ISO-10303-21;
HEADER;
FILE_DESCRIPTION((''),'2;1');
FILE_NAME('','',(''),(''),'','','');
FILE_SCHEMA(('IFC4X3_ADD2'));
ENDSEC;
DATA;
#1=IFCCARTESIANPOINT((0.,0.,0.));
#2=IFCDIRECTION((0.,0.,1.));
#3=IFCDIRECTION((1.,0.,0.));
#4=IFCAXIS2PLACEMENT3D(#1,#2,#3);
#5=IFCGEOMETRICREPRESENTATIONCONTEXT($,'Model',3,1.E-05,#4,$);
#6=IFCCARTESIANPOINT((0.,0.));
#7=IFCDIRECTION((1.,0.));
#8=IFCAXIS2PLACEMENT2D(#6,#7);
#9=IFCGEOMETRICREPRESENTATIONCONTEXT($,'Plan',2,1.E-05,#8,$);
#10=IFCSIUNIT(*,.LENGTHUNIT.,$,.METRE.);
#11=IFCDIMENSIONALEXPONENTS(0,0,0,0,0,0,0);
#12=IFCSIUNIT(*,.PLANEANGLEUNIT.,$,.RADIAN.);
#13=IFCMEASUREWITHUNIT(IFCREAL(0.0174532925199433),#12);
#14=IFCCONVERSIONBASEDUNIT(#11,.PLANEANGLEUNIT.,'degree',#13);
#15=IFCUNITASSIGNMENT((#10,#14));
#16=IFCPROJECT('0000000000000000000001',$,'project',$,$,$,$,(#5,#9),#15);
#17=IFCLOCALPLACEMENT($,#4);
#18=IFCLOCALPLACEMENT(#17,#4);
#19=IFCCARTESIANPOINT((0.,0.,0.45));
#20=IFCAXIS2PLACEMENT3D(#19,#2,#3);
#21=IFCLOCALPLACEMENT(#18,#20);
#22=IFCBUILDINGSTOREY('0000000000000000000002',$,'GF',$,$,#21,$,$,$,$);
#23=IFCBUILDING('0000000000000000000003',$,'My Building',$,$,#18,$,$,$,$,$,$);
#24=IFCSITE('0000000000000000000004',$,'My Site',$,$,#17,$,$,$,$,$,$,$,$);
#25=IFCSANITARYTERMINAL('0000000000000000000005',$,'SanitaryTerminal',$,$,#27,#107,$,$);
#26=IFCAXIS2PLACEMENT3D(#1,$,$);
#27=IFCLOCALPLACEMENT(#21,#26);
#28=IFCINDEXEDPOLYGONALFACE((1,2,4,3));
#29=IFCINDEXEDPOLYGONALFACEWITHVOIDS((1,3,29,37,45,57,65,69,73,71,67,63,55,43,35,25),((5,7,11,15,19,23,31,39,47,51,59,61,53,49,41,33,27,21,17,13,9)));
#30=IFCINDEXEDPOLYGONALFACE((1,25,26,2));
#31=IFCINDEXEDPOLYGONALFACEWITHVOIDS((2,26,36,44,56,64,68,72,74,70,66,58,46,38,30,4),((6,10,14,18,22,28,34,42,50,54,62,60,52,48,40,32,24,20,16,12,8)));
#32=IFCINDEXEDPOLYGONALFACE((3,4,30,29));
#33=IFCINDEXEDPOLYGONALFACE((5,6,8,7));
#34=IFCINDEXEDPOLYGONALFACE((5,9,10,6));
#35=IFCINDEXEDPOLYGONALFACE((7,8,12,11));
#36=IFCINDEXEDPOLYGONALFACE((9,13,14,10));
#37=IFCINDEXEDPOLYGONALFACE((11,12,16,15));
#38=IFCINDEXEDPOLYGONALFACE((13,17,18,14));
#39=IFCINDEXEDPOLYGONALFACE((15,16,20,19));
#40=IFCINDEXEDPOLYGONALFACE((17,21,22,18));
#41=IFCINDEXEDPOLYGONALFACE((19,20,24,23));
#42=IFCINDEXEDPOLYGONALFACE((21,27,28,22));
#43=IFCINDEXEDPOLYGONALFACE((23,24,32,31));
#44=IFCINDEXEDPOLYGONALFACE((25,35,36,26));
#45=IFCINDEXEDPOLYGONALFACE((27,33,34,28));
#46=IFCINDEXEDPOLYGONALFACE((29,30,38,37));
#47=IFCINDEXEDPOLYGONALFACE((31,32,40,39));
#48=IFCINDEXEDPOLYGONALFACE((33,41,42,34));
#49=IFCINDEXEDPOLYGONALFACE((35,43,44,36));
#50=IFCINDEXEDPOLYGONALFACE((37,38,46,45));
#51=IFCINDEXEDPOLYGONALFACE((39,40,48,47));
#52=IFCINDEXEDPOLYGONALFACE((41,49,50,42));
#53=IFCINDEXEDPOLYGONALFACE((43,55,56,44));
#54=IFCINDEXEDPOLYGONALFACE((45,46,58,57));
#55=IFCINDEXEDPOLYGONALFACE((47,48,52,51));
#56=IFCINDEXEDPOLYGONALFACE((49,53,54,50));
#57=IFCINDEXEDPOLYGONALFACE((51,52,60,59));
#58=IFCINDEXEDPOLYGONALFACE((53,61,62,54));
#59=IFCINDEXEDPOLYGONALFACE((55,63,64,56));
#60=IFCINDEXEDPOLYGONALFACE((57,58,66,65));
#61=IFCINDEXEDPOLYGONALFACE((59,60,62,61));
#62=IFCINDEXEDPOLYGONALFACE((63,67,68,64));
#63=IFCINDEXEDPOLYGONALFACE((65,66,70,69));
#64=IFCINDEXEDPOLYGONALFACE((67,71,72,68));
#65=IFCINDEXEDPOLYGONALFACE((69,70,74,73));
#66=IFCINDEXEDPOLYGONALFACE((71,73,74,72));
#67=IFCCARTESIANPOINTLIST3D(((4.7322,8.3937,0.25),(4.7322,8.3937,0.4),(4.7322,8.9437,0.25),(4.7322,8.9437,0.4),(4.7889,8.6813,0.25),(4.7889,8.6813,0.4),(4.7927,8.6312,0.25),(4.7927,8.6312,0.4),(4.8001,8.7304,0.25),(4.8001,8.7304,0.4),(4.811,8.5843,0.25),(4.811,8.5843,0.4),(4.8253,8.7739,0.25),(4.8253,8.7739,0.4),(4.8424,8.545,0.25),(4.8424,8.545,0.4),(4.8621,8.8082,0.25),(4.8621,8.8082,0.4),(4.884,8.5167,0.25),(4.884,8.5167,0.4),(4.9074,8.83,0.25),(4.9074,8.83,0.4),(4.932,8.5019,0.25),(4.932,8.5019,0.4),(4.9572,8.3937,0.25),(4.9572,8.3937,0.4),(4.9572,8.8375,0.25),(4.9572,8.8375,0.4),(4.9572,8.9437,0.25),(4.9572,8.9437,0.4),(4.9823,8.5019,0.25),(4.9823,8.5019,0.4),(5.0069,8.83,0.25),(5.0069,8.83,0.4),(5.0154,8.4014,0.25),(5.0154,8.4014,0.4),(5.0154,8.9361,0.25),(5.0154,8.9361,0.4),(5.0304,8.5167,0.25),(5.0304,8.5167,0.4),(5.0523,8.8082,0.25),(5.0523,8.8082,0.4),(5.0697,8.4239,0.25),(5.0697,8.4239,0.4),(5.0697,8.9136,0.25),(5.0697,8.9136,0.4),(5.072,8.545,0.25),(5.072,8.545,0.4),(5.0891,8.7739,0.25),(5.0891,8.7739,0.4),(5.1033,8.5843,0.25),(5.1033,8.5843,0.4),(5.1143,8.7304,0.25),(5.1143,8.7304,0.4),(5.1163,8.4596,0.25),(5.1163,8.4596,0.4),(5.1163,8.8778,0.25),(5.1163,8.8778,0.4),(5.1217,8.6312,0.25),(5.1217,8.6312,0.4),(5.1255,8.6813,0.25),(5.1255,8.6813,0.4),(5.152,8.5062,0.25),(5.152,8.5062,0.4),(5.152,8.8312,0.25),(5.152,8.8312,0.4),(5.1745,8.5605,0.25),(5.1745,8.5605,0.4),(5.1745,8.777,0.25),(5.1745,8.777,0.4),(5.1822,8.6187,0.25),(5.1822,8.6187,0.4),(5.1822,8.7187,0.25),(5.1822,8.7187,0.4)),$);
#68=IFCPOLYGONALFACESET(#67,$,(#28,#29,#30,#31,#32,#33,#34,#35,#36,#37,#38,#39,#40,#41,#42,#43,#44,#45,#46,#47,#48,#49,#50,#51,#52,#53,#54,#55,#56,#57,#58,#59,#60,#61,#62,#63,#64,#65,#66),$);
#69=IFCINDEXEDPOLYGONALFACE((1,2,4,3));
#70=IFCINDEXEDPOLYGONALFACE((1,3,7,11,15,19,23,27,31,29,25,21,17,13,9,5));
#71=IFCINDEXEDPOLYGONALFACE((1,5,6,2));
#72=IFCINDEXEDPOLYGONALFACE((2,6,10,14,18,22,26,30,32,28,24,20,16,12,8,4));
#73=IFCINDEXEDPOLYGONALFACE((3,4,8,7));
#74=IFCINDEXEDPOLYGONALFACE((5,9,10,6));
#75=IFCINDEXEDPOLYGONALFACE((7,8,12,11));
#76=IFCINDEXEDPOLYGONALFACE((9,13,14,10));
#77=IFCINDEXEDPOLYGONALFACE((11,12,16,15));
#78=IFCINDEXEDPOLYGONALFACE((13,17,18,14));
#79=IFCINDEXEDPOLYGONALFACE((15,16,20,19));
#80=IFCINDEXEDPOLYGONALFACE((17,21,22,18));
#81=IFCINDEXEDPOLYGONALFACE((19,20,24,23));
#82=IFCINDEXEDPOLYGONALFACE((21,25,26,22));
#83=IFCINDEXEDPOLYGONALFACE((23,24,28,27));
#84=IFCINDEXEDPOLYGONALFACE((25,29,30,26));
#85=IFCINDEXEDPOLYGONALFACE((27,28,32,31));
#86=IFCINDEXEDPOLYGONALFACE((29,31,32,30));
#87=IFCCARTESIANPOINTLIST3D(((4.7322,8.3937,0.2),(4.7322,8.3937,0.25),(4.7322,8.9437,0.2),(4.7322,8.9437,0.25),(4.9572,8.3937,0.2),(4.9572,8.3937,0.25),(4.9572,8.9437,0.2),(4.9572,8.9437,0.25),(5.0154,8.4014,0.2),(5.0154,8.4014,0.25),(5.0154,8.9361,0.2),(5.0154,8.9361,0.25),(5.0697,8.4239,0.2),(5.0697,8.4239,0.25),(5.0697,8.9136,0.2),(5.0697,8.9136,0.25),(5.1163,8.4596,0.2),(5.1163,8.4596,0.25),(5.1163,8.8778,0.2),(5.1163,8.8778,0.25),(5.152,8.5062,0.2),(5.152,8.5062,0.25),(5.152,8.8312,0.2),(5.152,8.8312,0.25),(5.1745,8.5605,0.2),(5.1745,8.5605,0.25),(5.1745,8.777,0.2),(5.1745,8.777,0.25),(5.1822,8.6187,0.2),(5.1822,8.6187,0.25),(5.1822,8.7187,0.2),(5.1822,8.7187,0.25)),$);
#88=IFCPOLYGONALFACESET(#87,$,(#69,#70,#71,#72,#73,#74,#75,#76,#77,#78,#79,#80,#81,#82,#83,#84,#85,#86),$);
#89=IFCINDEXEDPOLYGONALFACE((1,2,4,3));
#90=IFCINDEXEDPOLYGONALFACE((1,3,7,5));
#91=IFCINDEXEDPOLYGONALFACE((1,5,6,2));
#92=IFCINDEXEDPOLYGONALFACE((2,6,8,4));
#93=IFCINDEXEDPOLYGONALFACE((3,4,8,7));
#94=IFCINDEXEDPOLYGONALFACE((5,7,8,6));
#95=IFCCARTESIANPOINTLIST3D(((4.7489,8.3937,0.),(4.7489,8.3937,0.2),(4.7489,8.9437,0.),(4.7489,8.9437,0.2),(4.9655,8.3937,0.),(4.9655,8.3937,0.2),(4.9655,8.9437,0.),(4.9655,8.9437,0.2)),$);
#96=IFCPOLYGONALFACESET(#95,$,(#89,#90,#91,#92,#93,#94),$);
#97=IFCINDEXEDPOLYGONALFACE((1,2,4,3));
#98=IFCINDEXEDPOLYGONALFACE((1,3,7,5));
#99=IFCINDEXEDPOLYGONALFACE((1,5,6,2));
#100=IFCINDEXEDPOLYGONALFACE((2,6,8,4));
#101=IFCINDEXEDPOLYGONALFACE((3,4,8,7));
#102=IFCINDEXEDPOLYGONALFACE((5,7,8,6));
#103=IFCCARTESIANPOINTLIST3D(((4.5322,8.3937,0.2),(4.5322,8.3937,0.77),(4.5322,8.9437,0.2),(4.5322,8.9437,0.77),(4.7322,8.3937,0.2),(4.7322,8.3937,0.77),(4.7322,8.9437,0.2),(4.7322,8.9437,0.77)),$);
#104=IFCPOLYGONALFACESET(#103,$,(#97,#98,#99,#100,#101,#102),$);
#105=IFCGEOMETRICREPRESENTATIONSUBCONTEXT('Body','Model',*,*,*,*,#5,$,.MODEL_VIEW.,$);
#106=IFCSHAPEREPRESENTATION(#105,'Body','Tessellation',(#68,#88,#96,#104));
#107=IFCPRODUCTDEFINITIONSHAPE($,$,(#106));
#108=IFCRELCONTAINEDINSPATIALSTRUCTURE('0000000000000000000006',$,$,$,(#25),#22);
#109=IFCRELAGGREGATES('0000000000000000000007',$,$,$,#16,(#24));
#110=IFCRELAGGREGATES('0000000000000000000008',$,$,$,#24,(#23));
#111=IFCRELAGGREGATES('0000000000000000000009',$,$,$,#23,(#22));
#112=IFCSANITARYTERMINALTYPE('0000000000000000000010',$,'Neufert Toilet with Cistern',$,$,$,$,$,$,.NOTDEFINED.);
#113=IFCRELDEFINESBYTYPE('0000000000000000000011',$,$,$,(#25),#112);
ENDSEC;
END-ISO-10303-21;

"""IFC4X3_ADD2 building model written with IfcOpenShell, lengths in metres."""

from ifc_helpers import new_model, entity, si_unit, converted_unit, frame, frame_2d, origin_with_axes, origin_2d_with_axis, place, context, subcontext, project, spatial, line, arc, indexed_curve, circle_curve, outline, extrude, shape, source, transform, mapped, type_object, type_shapes, element, save


model = new_model("IFC4X3_ADD2")

# Units and contexts
model_context = context("Model", 3, precision=1e-05, world=origin_with_axes())
plan_context = context("Plan", 2, precision=1e-05, world=origin_2d_with_axis())
body_context_1 = subcontext(model_context, "Body", "Model", "MODEL_VIEW")
body_context_2 = subcontext(plan_context, "Body", "Plan", "PLAN_VIEW")
ifc_project = project(units=[si_unit("LENGTHUNIT", "METRE"), converted_unit("PLANEANGLEUNIT", "degree", entity("IfcReal", 0.0174532925199433), si_unit("PLANEANGLEUNIT", "RADIAN"), dimensions=[0, 0, 0, 0, 0, 0, 0])], contexts=[model_context, plan_context])

# Site, building, storey
site_placement = place(None, origin_with_axes())
site = spatial("IfcSite", under=ifc_project, at=site_placement, Name="My Site")
building_placement = place(site_placement, origin_with_axes())
building = spatial("IfcBuilding", under=site, at=building_placement, Name="My Building")
storey_placement = place(building_placement, frame((0.0, 0.0, 0.45), z_axis=(0.0, 0.0, 1.0), x_axis=(1.0, 0.0, 0.0)))
storey = spatial("IfcBuildingStorey", under=building, at=storey_placement, Name="GF")

# Sanitary terminal
sanitary_terminal_type_1 = type_object("IfcSanitaryTerminalType", Name="Neufert Toilet with Cistern", PredefinedType="NOTDEFINED")
shared_shape_1 = source(origin_with_axes(), body_context_1, "Body", "SweptSolid", [
    extrude(outline(indexed_curve([(-0.275, -0.2), (0.275, -0.2), (0.275, -0.425), (0.2091, -0.5841), (0.05, -0.65), (-0.05, -0.65), (-0.2091, -0.5841), (-0.275, -0.425), (0.0, -0.5938), (0.0, -0.2563)], segments=[arc(8, 7, 6), line(6, 5), arc(5, 4, 3), line(3, 2), line(2, 1), line(1, 8)], self_intersect=False), holes=[circle_curve(frame_2d((0.0, -0.425)), 0.1687)]), frame((0.0, 0.0, 0.25), z_axis=(0.0, 0.0, 1.0), x_axis=(1.0, 0.0, 0.0)), (0.0, 0.0, 1.0), 0.15),
    extrude(outline(indexed_curve([(-0.275, -0.2), (0.275, -0.2), (0.275, -0.425), (0.2091, -0.5841), (0.05, -0.65), (-0.05, -0.65), (-0.2091, -0.5841), (-0.275, -0.425)], segments=[line(1, 2), line(2, 3), arc(3, 4, 5), line(5, 6), arc(6, 7, 8), line(8, 1)])), frame((0.0, 0.0, 0.2), z_axis=(0.0, 0.0, 1.0), x_axis=(1.0, 0.0, 0.0)), (0.0, 0.0, 1.0), 0.05),
    extrude(outline(indexed_curve([(-0.275, -0.2167), (0.275, -0.2167), (0.275, -0.4333), (-0.275, -0.4333)], segments=[line(1, 2, 3, 4, 1)])), origin_with_axes(), (0.0, 0.0, 1.0), 0.2),
    extrude(outline(indexed_curve([(-0.275, 0.0), (0.275, 0.0), (0.275, -0.2), (-0.275, -0.2)], segments=[line(1, 2, 3, 4, 1)])), frame((0.0, 0.0, 0.2), z_axis=(0.0, 0.0, 1.0), x_axis=(1.0, 0.0, 0.0)), (0.0, 0.0, 1.0), 0.57),
])
shared_shape_2 = source(origin_with_axes(), body_context_2, "Body", "Curve2D", [
    entity("IfcIndexedPolyCurve", entity("IfcCartesianPointList2D", [[-0.275, 0.0], [0.275, 0.0], [0.275, -0.2], [-0.275, -0.2]]), [entity("IfcLineIndex", [1, 2, 3, 4, 1])]),
    entity("IfcIndexedPolyCurve", entity("IfcCartesianPointList2D", [[0.165, -0.2], [0.1925, -0.335]])),
    entity("IfcTrimmedCurve", entity("IfcEllipse", entity("IfcAxis2Placement2D", entity("IfcCartesianPoint", [0.0, -0.335]), entity("IfcDirection", [1.0, 0.0])), 0.1925, 0.315), [entity("IfcCartesianPoint", [-0.1925, -0.335])], [entity("IfcCartesianPoint", [0.1925, -0.335])], True, "CARTESIAN"),
    entity("IfcIndexedPolyCurve", entity("IfcCartesianPointList2D", [[-0.165, -0.2], [-0.1925, -0.335]])),
    entity("IfcEllipse", entity("IfcAxis2Placement2D", entity("IfcCartesianPoint", [0.0, -0.452]), entity("IfcDirection", [1.0, 0.0])), 0.1313, 0.1575),
    entity("IfcIndexedPolyCurve", entity("IfcCartesianPointList2D", [[-0.0344, -0.452], [-0.0344, -0.4295], [0.0344, -0.4295], [0.0344, -0.452]])),
    entity("IfcTrimmedCurve", entity("IfcEllipse", entity("IfcAxis2Placement2D", entity("IfcCartesianPoint", [0.0, -0.452]), entity("IfcDirection", [1.0, 0.0])), 0.0344, 0.0225), [entity("IfcCartesianPoint", [-0.0344, -0.452])], [entity("IfcCartesianPoint", [0.0344, -0.452])], True, "CARTESIAN"),
])
type_shapes(sanitary_terminal_type_1, [shared_shape_1, shared_shape_2])
sanitary_terminal_1_placement = place(storey_placement, frame((4.5322, 8.6687, 0.0), z_axis=(0.0, 0.0, 1.0), x_axis=(0.0, 1.0, 0.0)))
element("IfcSanitaryTerminal", 1, at=sanitary_terminal_1_placement, inside=storey, type_object=sanitary_terminal_type_1, Name="SanitaryTerminal", shapes=[
    shape(body_context_1, "Body", "MappedRepresentation", [mapped(shared_shape_1, transform((0.0, 0.0, 0.0), x_axis=(1.0, 0.0, 0.0), y_axis=(0.0, 1.0, 0.0), z_axis=(0.0, 0.0, 1.0), scale=1.0))]),
    shape(body_context_2, "Body", "MappedRepresentation", [mapped(shared_shape_2, transform((0.0, 0.0, 0.0), x_axis=(1.0, 0.0, 0.0), y_axis=(0.0, 1.0, 0.0), z_axis=(0.0, 0.0, 1.0), scale=1.0))]),
])

save(model, "model.ifc")
